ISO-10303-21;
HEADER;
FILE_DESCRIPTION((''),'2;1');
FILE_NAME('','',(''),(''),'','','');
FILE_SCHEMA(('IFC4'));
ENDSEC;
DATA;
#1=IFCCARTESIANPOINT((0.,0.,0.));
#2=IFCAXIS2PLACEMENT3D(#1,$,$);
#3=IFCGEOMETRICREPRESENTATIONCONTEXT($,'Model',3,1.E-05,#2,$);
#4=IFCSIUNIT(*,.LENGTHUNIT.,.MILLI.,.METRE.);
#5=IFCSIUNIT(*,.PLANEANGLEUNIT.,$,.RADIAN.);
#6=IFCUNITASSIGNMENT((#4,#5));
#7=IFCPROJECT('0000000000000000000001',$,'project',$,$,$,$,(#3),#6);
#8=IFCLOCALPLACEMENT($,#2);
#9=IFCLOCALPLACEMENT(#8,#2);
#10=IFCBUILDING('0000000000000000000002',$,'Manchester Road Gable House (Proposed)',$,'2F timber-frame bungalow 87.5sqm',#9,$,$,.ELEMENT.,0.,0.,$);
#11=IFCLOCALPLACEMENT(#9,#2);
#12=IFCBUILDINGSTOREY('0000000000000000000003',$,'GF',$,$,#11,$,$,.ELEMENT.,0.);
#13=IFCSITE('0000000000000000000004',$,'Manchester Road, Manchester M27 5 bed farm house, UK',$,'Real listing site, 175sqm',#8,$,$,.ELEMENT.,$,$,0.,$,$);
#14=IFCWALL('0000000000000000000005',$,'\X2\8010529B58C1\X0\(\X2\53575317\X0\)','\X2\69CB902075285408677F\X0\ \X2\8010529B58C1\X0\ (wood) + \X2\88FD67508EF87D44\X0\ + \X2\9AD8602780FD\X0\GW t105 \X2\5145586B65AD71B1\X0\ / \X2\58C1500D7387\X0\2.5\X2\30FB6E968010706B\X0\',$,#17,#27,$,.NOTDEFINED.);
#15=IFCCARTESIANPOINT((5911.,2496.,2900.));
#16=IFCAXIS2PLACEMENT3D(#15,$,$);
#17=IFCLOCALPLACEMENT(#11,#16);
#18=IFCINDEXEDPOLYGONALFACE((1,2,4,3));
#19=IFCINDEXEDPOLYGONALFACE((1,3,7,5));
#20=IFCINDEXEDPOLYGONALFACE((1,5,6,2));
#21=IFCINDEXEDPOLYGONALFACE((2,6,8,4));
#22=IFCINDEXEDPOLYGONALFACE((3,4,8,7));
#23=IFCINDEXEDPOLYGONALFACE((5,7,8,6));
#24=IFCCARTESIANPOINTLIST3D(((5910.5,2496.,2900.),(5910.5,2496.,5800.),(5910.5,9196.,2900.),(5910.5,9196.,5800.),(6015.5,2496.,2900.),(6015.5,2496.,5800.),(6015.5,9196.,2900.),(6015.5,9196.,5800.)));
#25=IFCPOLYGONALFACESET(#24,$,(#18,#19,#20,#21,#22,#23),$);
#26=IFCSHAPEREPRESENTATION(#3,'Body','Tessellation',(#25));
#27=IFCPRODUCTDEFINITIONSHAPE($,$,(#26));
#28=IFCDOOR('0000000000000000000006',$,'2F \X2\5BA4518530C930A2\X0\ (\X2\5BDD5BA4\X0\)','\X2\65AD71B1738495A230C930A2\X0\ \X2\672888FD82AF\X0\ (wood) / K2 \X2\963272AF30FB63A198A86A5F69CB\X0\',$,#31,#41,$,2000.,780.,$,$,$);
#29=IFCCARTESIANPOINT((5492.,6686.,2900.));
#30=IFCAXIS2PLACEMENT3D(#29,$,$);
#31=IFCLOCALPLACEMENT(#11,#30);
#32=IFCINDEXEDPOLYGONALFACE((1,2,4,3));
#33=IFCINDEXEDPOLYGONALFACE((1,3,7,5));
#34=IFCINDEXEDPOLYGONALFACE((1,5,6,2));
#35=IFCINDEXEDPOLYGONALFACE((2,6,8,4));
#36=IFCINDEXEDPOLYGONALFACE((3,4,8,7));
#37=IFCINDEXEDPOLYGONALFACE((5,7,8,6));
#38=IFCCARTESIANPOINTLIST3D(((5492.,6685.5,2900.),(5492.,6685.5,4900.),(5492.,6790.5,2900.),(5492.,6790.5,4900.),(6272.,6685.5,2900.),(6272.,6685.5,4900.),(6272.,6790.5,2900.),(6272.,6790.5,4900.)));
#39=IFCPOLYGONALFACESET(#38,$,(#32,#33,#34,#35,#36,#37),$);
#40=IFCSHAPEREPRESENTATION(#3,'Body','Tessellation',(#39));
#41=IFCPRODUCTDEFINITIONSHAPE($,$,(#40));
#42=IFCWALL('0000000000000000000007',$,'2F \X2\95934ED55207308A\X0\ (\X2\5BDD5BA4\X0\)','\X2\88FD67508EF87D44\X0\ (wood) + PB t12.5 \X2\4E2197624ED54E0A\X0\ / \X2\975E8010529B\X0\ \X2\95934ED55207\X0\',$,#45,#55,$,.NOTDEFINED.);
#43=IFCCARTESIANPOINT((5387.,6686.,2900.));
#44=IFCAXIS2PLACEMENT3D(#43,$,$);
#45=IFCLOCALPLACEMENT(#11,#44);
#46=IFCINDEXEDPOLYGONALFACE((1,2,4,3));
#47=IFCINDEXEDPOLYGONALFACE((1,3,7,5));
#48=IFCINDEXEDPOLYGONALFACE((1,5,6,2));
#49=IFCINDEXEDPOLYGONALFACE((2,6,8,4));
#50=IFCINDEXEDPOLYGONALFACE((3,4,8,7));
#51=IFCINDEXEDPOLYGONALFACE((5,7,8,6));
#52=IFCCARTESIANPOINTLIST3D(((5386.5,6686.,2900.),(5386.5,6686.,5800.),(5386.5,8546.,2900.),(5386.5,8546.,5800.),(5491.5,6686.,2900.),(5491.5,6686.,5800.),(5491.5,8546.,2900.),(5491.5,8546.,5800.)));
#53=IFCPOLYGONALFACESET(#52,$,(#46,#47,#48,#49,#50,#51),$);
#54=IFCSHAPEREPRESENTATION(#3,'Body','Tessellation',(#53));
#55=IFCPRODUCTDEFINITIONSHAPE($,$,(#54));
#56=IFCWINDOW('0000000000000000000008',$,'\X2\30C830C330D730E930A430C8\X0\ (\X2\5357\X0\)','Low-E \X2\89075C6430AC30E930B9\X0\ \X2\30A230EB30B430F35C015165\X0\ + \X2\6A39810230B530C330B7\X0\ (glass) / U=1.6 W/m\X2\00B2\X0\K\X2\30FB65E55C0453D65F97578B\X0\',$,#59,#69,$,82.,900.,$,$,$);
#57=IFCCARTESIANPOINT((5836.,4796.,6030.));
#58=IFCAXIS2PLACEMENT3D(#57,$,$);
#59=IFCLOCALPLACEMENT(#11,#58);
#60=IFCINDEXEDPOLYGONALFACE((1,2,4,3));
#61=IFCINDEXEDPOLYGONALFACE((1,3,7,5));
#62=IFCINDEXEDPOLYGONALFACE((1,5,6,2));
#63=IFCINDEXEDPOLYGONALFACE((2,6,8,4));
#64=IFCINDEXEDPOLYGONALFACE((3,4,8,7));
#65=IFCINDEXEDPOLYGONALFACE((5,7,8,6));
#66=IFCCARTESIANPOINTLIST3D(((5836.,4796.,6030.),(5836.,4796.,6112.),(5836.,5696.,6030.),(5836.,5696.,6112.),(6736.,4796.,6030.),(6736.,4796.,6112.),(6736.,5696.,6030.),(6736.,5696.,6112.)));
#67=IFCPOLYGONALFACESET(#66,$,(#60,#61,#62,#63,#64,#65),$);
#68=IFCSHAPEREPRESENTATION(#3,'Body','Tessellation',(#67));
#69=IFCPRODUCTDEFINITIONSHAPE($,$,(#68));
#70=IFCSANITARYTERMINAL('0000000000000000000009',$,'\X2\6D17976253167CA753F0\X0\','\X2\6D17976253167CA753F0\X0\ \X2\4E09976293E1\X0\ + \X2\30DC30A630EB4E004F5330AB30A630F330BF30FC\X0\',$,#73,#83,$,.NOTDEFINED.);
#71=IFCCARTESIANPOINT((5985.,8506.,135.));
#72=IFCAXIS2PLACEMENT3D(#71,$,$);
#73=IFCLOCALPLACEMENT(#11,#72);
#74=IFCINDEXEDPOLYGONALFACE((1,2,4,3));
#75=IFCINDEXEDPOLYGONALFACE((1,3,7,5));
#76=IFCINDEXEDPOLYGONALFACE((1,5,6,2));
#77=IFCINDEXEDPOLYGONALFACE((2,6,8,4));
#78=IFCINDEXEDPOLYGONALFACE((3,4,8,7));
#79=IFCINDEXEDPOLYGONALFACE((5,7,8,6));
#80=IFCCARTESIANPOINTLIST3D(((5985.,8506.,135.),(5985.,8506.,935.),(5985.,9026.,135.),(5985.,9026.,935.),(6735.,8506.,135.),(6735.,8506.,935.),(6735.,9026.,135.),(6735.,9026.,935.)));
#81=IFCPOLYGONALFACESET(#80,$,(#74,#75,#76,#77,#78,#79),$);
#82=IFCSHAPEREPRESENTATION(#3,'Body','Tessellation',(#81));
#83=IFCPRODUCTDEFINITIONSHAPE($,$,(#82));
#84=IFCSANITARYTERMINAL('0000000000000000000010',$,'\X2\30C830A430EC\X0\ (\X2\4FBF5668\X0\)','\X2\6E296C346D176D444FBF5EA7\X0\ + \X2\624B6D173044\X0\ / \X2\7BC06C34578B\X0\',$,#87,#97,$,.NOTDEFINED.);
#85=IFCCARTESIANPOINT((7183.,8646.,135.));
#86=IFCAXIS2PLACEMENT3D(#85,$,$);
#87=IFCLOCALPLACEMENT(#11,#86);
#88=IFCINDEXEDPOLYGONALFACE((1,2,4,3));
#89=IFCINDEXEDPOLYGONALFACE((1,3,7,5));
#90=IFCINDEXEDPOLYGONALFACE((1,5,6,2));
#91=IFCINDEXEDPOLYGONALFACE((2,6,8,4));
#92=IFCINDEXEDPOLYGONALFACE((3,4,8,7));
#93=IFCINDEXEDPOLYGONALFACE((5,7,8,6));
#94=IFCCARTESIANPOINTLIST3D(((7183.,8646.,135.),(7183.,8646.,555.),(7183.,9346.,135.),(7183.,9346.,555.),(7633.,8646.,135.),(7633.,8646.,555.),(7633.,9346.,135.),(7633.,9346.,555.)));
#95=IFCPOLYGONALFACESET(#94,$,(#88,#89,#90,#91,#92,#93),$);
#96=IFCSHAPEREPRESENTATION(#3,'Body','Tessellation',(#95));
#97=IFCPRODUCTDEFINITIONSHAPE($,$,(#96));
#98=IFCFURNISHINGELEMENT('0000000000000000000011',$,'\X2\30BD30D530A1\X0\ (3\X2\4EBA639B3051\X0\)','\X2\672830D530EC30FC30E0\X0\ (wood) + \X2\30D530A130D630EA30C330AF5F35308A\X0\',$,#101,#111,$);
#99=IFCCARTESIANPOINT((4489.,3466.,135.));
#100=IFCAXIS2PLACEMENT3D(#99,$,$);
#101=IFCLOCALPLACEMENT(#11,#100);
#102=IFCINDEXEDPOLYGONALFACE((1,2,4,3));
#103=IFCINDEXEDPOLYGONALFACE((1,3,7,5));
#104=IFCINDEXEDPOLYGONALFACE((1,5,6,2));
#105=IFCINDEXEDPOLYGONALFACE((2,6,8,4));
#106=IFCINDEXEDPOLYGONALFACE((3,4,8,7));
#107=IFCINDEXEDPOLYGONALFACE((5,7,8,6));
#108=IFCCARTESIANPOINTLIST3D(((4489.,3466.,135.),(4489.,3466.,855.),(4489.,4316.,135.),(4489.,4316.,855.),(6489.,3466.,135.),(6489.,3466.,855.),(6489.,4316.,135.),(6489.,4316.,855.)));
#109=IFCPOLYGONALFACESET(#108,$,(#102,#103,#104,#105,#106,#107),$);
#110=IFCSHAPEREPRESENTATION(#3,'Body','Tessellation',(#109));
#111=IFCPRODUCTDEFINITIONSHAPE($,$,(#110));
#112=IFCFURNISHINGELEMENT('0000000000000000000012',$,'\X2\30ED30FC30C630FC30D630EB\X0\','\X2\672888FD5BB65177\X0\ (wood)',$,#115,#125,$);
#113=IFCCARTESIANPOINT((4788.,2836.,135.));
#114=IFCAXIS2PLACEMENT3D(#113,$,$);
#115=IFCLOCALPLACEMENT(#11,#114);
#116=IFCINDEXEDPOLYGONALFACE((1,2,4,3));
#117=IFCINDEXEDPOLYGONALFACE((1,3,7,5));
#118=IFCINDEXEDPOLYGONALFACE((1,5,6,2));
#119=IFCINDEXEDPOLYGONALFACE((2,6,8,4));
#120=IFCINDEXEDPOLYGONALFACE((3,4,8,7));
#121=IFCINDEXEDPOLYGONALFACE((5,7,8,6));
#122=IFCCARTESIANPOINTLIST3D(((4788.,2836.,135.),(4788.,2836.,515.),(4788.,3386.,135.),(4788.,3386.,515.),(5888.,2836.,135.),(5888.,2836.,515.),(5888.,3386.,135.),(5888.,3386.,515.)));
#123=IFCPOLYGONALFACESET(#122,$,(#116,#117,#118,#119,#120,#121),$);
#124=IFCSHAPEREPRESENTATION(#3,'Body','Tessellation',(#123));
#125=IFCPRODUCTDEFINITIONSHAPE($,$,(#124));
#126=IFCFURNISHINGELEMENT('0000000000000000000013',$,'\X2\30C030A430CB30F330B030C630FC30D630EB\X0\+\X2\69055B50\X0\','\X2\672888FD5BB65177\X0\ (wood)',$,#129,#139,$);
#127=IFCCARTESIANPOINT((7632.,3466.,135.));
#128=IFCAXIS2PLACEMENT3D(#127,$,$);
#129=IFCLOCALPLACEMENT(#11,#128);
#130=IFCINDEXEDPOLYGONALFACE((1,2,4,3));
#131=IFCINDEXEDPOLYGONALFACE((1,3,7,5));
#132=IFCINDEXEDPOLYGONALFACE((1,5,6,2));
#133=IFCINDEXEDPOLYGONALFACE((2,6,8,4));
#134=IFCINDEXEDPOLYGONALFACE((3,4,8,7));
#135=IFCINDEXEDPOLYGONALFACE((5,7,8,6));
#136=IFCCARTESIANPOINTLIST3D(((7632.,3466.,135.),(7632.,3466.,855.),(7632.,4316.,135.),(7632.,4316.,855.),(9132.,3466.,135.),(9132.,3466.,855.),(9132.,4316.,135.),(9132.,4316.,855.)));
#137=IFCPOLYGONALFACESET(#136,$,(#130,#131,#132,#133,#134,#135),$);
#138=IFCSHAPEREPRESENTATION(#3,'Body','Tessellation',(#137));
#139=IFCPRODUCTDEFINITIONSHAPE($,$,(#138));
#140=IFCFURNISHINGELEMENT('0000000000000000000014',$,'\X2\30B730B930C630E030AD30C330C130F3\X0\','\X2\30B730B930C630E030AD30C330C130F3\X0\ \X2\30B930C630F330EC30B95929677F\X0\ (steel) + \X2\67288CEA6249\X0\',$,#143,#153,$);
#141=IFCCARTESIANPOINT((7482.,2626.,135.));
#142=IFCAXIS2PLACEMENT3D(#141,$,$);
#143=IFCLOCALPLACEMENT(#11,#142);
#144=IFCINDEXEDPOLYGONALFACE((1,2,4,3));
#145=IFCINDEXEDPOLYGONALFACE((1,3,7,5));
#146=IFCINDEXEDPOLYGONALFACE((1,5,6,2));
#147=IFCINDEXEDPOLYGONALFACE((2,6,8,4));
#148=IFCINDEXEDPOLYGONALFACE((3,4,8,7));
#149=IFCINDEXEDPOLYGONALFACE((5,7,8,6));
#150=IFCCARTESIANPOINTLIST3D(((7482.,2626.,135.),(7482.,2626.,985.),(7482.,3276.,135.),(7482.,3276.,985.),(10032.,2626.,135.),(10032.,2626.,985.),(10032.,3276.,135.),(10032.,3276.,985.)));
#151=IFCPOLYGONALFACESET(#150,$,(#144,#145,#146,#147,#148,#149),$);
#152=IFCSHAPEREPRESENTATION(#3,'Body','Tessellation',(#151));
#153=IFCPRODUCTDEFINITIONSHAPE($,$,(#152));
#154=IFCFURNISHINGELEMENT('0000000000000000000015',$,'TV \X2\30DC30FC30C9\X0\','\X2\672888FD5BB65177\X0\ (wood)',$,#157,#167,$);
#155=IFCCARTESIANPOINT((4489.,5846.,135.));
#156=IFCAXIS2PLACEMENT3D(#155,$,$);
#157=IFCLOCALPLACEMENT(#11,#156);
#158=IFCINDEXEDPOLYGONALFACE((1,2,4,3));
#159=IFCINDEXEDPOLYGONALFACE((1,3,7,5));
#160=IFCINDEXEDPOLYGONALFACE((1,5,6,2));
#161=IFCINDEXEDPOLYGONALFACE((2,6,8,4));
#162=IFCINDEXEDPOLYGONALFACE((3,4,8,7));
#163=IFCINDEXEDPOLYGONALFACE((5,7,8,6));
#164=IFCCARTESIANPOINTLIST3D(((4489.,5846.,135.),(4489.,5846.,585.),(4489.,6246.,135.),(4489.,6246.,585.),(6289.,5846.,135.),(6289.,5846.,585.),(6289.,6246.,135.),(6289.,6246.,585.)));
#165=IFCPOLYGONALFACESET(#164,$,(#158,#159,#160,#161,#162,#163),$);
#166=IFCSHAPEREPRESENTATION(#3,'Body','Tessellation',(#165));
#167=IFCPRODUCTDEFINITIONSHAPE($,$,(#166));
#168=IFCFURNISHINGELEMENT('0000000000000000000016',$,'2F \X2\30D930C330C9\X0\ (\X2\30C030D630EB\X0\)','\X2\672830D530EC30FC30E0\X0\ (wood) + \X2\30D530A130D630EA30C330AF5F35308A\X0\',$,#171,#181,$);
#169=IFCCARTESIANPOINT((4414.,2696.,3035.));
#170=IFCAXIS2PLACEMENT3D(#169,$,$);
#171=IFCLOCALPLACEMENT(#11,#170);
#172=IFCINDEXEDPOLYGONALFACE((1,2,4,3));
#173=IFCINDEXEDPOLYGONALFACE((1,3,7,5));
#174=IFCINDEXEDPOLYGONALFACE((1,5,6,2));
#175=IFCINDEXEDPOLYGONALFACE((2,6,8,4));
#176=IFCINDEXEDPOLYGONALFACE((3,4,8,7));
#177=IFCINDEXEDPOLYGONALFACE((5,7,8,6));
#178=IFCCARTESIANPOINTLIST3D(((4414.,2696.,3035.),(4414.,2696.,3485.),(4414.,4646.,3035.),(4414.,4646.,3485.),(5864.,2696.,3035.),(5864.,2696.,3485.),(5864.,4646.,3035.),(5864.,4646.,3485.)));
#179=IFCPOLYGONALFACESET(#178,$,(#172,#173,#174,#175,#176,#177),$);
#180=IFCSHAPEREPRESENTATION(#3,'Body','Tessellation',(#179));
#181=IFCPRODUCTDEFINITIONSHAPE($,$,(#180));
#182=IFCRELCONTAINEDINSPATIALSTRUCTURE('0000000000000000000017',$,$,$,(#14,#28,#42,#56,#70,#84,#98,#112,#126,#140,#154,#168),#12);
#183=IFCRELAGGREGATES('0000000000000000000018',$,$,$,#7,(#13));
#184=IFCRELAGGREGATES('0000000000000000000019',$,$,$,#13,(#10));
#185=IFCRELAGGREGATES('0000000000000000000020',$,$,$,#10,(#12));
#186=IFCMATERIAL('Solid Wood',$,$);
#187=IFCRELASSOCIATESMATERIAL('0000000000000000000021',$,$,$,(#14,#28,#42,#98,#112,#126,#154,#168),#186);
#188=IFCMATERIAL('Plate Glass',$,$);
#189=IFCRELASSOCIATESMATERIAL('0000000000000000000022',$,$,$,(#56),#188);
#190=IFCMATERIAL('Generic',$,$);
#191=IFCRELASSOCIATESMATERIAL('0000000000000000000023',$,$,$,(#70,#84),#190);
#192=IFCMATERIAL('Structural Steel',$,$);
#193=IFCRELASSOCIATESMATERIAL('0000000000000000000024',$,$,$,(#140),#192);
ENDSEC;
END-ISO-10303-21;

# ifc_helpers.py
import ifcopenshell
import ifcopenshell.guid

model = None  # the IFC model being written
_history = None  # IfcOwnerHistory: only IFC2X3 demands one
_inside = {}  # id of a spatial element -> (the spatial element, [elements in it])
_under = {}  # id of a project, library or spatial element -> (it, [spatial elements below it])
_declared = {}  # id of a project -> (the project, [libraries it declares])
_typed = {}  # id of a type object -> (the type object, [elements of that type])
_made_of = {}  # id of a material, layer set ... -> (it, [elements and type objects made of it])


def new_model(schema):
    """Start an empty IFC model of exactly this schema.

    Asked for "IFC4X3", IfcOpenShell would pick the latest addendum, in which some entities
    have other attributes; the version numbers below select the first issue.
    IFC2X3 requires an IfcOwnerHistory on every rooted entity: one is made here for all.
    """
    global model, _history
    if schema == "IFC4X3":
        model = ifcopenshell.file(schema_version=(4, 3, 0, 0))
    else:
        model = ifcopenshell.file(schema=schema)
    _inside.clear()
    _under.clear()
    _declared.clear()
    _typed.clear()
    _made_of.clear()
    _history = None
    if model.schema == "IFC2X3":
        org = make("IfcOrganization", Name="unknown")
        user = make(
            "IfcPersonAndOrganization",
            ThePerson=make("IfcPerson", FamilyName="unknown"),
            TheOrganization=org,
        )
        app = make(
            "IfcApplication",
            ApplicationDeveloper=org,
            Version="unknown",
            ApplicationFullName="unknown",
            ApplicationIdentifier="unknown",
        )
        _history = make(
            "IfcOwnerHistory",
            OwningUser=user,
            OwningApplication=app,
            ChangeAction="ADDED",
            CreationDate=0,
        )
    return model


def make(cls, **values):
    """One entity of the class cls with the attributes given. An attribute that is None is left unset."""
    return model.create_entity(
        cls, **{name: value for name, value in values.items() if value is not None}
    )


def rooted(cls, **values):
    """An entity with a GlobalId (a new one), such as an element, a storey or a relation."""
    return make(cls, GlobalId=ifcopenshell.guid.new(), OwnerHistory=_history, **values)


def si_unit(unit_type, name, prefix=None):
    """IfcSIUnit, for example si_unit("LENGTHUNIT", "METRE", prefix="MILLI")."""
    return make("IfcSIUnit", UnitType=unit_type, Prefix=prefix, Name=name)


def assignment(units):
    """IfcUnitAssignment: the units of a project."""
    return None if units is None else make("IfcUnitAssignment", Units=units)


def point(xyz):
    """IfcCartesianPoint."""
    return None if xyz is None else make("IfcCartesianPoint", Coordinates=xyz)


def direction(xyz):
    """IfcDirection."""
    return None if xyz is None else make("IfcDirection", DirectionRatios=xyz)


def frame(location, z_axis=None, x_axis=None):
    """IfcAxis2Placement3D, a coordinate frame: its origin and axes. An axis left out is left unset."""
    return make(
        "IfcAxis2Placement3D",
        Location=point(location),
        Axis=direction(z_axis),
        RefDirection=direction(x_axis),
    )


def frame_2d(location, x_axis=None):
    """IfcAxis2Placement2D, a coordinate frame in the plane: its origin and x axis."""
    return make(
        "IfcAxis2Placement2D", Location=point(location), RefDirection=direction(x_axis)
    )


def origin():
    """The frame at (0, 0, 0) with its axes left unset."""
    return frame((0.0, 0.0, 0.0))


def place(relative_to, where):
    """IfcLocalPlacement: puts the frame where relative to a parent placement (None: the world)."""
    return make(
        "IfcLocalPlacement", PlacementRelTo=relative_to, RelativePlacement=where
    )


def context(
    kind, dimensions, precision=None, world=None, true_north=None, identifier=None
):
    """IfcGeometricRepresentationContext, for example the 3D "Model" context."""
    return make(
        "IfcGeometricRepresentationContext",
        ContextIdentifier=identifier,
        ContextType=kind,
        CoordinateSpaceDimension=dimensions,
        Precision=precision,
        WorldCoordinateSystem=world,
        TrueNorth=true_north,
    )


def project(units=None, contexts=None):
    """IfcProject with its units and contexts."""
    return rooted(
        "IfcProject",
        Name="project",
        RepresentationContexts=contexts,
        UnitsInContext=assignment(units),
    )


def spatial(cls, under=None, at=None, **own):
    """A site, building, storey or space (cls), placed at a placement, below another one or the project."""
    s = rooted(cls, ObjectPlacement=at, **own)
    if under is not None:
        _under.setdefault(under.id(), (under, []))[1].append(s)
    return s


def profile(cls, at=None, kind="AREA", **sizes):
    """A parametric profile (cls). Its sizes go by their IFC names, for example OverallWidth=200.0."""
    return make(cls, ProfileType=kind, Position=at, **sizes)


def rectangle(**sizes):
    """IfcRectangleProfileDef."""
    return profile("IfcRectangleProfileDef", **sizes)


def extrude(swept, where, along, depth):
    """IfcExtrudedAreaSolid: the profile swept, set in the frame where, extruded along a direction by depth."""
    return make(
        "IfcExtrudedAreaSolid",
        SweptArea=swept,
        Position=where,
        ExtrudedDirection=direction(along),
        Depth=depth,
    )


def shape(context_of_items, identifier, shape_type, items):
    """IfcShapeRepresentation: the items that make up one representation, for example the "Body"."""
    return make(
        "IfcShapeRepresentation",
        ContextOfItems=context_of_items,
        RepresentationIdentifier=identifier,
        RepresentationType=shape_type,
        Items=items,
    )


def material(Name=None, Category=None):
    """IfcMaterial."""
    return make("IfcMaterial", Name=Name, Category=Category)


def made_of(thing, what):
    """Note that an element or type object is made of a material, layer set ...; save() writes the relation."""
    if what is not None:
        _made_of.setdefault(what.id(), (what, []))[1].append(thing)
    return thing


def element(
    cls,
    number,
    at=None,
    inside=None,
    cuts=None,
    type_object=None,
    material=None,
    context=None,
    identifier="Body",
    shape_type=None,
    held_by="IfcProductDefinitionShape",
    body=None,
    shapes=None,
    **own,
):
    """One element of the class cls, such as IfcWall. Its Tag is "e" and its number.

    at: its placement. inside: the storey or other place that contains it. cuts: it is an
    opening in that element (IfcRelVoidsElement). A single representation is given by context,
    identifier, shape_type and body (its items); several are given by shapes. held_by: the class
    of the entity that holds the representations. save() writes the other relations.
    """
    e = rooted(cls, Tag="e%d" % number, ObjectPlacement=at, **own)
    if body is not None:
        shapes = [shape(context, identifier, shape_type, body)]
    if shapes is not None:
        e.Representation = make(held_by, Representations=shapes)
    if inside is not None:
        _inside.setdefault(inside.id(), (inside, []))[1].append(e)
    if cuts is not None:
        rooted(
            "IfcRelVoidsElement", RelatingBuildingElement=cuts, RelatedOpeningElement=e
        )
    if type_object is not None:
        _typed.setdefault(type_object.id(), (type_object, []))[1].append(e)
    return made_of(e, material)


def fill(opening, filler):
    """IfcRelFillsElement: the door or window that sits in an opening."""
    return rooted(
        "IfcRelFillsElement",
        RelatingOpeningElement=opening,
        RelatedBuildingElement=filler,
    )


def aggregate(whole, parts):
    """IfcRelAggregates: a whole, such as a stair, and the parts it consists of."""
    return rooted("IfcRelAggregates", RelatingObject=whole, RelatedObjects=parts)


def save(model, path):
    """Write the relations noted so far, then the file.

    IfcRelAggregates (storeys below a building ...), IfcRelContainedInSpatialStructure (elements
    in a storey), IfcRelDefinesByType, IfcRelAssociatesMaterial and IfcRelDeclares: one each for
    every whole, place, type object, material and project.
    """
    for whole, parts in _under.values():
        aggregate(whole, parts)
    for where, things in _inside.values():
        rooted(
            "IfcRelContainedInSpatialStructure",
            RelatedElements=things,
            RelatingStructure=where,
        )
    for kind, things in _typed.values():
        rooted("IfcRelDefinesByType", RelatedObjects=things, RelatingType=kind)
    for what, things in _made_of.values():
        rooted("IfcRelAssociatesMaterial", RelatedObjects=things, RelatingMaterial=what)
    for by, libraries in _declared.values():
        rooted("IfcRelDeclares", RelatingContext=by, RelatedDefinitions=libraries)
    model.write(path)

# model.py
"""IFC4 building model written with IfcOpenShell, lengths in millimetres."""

from ifc_helpers import new_model, si_unit, frame, frame_2d, origin, place, context, project, spatial, rectangle, extrude, material, element, fill, save


model = new_model("IFC4")

# Units and contexts
model_context = context("Model", 3, precision=1e-05, world=origin())
ifc_project = project(units=[si_unit("LENGTHUNIT", "METRE", prefix="MILLI"), si_unit("PLANEANGLEUNIT", "RADIAN")], contexts=[model_context])

# Site, building, storey
site_placement = place(None, origin())
site = spatial("IfcSite", under=ifc_project, at=site_placement, Name="Manchester Road, Manchester M27 5 bed farm house, UK", ObjectType="Real listing site, 175sqm", CompositionType="ELEMENT", RefElevation=0.0)
building_placement = place(site_placement, origin())
building = spatial("IfcBuilding", under=site, at=building_placement, Name="Manchester Road Gable House (Proposed)", ObjectType="2F timber-frame bungalow 87.5sqm", CompositionType="ELEMENT", ElevationOfRefHeight=0.0, ElevationOfTerrain=0.0)
storey_placement = place(building_placement, origin())
storey = spatial("IfcBuildingStorey", under=building, at=storey_placement, Name="GF", CompositionType="ELEMENT", Elevation=0.0)

# Shared definitions
ifc_material_1 = material(Name="Solid Wood")

# Wall, opening, door
wall_1_placement = place(storey_placement, frame((5911.0, 2496.0, 2900.0)))
wall_1 = element("IfcWall", 1, at=wall_1_placement, inside=storey, material=ifc_material_1, Name="耐力壁(南北)", Description="構造用合板 耐力壁 (wood) + 製材軸組 + 高性能GW t105 充填断熱 / 壁倍率2.5・準耐火", PredefinedType="NOTDEFINED", context=model_context, shape_type="SweptSolid", body=[
    extrude(rectangle(XDim=105.0, YDim=6700.0, at=frame_2d((52.0, 3350.0))), frame((5911.0, 2496.0, 2900.0)), (0.0, 0.0, 1.0), 2900.0),
])
opening_1_placement = place(storey_placement, frame((5492.0, 6686.0, 2900.0)))
opening_1 = element("IfcOpeningElement", 2, at=opening_1_placement, cuts=wall_1, PredefinedType="NOTDEFINED", context=model_context, shape_type="SweptSolid", body=[
    extrude(rectangle(XDim=780.0, YDim=105.0, at=frame_2d((390.0, 52.0))), frame((5492.0, 6686.0, 2900.0)), (0.0, 0.0, 1.0), 2000.0),
])
door_1_placement = place(storey_placement, frame((5492.0, 6686.0, 2900.0)))
door_1 = element("IfcDoor", 3, at=door_1_placement, inside=storey, material=ifc_material_1, Name="2F 室内ドア (寝室)", Description="断熱玄関ドア 木製芯 (wood) / K2 防犯・採風機構", OverallHeight=2000.0, OverallWidth=780.0, context=model_context, shape_type="SweptSolid", body=[
    extrude(rectangle(XDim=780.0, YDim=105.0, at=frame_2d((390.0, 52.0))), frame((5492.0, 6686.0, 2900.0)), (0.0, 0.0, 1.0), 2000.0),
])
fill(opening_1, door_1)

# Wall
wall_2_placement = place(storey_placement, frame((5387.0, 6686.0, 2900.0)))
element("IfcWall", 4, at=wall_2_placement, inside=storey, material=ifc_material_1, Name="2F 間仕切り (寝室)", Description="製材軸組 (wood) + PB t12.5 両面仕上 / 非耐力 間仕切", PredefinedType="NOTDEFINED", context=model_context, shape_type="SweptSolid", body=[
    extrude(rectangle(XDim=105.0, YDim=1860.0, at=frame_2d((52.0, 930.0))), frame((5387.0, 6686.0, 2900.0)), (0.0, 0.0, 1.0), 2900.0),
])

# Window
ifc_material_2 = material(Name="Plate Glass")
window_placement = place(storey_placement, frame((5836.0, 4796.0, 6030.0)))
element("IfcWindow", 5, at=window_placement, inside=storey, material=ifc_material_2, Name="トップライト (南)", Description="Low-E 複層ガラス アルゴン封入 + 樹脂サッシ (glass) / U=1.6 W/m²K・日射取得型", OverallHeight=82.0, OverallWidth=900.0, context=model_context, shape_type="SweptSolid", body=[
    extrude(rectangle(XDim=900.0, YDim=900.0, at=frame_2d((450.0, 450.0))), frame((5836.0, 4796.0, 6030.0)), (0.0, 0.0, 1.0), 82.0),
])

# Sanitary terminals
ifc_material_3 = material(Name="Generic")
sanitary_terminal_1_placement = place(storey_placement, frame((5985.0, 8506.0, 135.0)))
element("IfcSanitaryTerminal", 6, at=sanitary_terminal_1_placement, inside=storey, material=ifc_material_3, Name="洗面化粧台", Description="洗面化粧台 三面鏡 + ボウル一体カウンター", PredefinedType="NOTDEFINED", context=model_context, shape_type="SweptSolid", body=[
    extrude(rectangle(XDim=750.0, YDim=520.0, at=frame_2d((375.0, 260.0))), frame((5985.0, 8506.0, 135.0)), (0.0, 0.0, 1.0), 800.0),
])
sanitary_terminal_2_placement = place(storey_placement, frame((7183.0, 8646.0, 135.0)))
element("IfcSanitaryTerminal", 7, at=sanitary_terminal_2_placement, inside=storey, material=ifc_material_3, Name="トイレ (便器)", Description="温水洗浄便座 + 手洗い / 節水型", PredefinedType="NOTDEFINED", context=model_context, shape_type="SweptSolid", body=[
    extrude(rectangle(XDim=450.0, YDim=700.0, at=frame_2d((225.0, 350.0))), frame((7183.0, 8646.0, 135.0)), (0.0, 0.0, 1.0), 420.0),
])

# Furnishing elements
furnishing_1_placement = place(storey_placement, frame((4489.0, 3466.0, 135.0)))
element("IfcFurnishingElement", 8, at=furnishing_1_placement, inside=storey, material=ifc_material_1, Name="ソファ (3人掛け)", Description="木フレーム (wood) + ファブリック張り", context=model_context, shape_type="SweptSolid", body=[
    extrude(rectangle(XDim=2000.0, YDim=850.0, at=frame_2d((1000.0, 425.0))), frame((4489.0, 3466.0, 135.0)), (0.0, 0.0, 1.0), 720.0),
])
furnishing_2_placement = place(storey_placement, frame((4788.0, 2836.0, 135.0)))
element("IfcFurnishingElement", 9, at=furnishing_2_placement, inside=storey, material=ifc_material_1, Name="ローテーブル", Description="木製家具 (wood)", context=model_context, shape_type="SweptSolid", body=[
    extrude(rectangle(XDim=1100.0, YDim=550.0, at=frame_2d((550.0, 275.0))), frame((4788.0, 2836.0, 135.0)), (0.0, 0.0, 1.0), 380.0),
])
furnishing_3_placement = place(storey_placement, frame((7632.0, 3466.0, 135.0)))
element("IfcFurnishingElement", 10, at=furnishing_3_placement, inside=storey, material=ifc_material_1, Name="ダイニングテーブル+椅子", Description="木製家具 (wood)", context=model_context, shape_type="SweptSolid", body=[
    extrude(rectangle(XDim=1500.0, YDim=850.0, at=frame_2d((750.0, 425.0))), frame((7632.0, 3466.0, 135.0)), (0.0, 0.0, 1.0), 720.0),
])
ifc_material_4 = material(Name="Structural Steel")
furnishing_4_placement = place(storey_placement, frame((7482.0, 2626.0, 135.0)))
element("IfcFurnishingElement", 11, at=furnishing_4_placement, inside=storey, material=ifc_material_4, Name="システムキッチン", Description="システムキッチン ステンレス天板 (steel) + 木質扉", context=model_context, shape_type="SweptSolid", body=[
    extrude(rectangle(XDim=2550.0, YDim=650.0, at=frame_2d((1275.0, 325.0))), frame((7482.0, 2626.0, 135.0)), (0.0, 0.0, 1.0), 850.0),
])
furnishing_5_placement = place(storey_placement, frame((4489.0, 5846.0, 135.0)))
element("IfcFurnishingElement", 12, at=furnishing_5_placement, inside=storey, material=ifc_material_1, Name="TV ボード", Description="木製家具 (wood)", context=model_context, shape_type="SweptSolid", body=[
    extrude(rectangle(XDim=1800.0, YDim=400.0, at=frame_2d((900.0, 200.0))), frame((4489.0, 5846.0, 135.0)), (0.0, 0.0, 1.0), 450.0),
])
furnishing_6_placement = place(storey_placement, frame((4414.0, 2696.0, 3035.0)))
element("IfcFurnishingElement", 13, at=furnishing_6_placement, inside=storey, material=ifc_material_1, Name="2F ベッド (ダブル)", Description="木フレーム (wood) + ファブリック張り", context=model_context, shape_type="SweptSolid", body=[
    extrude(rectangle(XDim=1450.0, YDim=1950.0, at=frame_2d((725.0, 975.0))), frame((4414.0, 2696.0, 3035.0)), (0.0, 0.0, 1.0), 450.0),
])

save(model, "model.ifc")
